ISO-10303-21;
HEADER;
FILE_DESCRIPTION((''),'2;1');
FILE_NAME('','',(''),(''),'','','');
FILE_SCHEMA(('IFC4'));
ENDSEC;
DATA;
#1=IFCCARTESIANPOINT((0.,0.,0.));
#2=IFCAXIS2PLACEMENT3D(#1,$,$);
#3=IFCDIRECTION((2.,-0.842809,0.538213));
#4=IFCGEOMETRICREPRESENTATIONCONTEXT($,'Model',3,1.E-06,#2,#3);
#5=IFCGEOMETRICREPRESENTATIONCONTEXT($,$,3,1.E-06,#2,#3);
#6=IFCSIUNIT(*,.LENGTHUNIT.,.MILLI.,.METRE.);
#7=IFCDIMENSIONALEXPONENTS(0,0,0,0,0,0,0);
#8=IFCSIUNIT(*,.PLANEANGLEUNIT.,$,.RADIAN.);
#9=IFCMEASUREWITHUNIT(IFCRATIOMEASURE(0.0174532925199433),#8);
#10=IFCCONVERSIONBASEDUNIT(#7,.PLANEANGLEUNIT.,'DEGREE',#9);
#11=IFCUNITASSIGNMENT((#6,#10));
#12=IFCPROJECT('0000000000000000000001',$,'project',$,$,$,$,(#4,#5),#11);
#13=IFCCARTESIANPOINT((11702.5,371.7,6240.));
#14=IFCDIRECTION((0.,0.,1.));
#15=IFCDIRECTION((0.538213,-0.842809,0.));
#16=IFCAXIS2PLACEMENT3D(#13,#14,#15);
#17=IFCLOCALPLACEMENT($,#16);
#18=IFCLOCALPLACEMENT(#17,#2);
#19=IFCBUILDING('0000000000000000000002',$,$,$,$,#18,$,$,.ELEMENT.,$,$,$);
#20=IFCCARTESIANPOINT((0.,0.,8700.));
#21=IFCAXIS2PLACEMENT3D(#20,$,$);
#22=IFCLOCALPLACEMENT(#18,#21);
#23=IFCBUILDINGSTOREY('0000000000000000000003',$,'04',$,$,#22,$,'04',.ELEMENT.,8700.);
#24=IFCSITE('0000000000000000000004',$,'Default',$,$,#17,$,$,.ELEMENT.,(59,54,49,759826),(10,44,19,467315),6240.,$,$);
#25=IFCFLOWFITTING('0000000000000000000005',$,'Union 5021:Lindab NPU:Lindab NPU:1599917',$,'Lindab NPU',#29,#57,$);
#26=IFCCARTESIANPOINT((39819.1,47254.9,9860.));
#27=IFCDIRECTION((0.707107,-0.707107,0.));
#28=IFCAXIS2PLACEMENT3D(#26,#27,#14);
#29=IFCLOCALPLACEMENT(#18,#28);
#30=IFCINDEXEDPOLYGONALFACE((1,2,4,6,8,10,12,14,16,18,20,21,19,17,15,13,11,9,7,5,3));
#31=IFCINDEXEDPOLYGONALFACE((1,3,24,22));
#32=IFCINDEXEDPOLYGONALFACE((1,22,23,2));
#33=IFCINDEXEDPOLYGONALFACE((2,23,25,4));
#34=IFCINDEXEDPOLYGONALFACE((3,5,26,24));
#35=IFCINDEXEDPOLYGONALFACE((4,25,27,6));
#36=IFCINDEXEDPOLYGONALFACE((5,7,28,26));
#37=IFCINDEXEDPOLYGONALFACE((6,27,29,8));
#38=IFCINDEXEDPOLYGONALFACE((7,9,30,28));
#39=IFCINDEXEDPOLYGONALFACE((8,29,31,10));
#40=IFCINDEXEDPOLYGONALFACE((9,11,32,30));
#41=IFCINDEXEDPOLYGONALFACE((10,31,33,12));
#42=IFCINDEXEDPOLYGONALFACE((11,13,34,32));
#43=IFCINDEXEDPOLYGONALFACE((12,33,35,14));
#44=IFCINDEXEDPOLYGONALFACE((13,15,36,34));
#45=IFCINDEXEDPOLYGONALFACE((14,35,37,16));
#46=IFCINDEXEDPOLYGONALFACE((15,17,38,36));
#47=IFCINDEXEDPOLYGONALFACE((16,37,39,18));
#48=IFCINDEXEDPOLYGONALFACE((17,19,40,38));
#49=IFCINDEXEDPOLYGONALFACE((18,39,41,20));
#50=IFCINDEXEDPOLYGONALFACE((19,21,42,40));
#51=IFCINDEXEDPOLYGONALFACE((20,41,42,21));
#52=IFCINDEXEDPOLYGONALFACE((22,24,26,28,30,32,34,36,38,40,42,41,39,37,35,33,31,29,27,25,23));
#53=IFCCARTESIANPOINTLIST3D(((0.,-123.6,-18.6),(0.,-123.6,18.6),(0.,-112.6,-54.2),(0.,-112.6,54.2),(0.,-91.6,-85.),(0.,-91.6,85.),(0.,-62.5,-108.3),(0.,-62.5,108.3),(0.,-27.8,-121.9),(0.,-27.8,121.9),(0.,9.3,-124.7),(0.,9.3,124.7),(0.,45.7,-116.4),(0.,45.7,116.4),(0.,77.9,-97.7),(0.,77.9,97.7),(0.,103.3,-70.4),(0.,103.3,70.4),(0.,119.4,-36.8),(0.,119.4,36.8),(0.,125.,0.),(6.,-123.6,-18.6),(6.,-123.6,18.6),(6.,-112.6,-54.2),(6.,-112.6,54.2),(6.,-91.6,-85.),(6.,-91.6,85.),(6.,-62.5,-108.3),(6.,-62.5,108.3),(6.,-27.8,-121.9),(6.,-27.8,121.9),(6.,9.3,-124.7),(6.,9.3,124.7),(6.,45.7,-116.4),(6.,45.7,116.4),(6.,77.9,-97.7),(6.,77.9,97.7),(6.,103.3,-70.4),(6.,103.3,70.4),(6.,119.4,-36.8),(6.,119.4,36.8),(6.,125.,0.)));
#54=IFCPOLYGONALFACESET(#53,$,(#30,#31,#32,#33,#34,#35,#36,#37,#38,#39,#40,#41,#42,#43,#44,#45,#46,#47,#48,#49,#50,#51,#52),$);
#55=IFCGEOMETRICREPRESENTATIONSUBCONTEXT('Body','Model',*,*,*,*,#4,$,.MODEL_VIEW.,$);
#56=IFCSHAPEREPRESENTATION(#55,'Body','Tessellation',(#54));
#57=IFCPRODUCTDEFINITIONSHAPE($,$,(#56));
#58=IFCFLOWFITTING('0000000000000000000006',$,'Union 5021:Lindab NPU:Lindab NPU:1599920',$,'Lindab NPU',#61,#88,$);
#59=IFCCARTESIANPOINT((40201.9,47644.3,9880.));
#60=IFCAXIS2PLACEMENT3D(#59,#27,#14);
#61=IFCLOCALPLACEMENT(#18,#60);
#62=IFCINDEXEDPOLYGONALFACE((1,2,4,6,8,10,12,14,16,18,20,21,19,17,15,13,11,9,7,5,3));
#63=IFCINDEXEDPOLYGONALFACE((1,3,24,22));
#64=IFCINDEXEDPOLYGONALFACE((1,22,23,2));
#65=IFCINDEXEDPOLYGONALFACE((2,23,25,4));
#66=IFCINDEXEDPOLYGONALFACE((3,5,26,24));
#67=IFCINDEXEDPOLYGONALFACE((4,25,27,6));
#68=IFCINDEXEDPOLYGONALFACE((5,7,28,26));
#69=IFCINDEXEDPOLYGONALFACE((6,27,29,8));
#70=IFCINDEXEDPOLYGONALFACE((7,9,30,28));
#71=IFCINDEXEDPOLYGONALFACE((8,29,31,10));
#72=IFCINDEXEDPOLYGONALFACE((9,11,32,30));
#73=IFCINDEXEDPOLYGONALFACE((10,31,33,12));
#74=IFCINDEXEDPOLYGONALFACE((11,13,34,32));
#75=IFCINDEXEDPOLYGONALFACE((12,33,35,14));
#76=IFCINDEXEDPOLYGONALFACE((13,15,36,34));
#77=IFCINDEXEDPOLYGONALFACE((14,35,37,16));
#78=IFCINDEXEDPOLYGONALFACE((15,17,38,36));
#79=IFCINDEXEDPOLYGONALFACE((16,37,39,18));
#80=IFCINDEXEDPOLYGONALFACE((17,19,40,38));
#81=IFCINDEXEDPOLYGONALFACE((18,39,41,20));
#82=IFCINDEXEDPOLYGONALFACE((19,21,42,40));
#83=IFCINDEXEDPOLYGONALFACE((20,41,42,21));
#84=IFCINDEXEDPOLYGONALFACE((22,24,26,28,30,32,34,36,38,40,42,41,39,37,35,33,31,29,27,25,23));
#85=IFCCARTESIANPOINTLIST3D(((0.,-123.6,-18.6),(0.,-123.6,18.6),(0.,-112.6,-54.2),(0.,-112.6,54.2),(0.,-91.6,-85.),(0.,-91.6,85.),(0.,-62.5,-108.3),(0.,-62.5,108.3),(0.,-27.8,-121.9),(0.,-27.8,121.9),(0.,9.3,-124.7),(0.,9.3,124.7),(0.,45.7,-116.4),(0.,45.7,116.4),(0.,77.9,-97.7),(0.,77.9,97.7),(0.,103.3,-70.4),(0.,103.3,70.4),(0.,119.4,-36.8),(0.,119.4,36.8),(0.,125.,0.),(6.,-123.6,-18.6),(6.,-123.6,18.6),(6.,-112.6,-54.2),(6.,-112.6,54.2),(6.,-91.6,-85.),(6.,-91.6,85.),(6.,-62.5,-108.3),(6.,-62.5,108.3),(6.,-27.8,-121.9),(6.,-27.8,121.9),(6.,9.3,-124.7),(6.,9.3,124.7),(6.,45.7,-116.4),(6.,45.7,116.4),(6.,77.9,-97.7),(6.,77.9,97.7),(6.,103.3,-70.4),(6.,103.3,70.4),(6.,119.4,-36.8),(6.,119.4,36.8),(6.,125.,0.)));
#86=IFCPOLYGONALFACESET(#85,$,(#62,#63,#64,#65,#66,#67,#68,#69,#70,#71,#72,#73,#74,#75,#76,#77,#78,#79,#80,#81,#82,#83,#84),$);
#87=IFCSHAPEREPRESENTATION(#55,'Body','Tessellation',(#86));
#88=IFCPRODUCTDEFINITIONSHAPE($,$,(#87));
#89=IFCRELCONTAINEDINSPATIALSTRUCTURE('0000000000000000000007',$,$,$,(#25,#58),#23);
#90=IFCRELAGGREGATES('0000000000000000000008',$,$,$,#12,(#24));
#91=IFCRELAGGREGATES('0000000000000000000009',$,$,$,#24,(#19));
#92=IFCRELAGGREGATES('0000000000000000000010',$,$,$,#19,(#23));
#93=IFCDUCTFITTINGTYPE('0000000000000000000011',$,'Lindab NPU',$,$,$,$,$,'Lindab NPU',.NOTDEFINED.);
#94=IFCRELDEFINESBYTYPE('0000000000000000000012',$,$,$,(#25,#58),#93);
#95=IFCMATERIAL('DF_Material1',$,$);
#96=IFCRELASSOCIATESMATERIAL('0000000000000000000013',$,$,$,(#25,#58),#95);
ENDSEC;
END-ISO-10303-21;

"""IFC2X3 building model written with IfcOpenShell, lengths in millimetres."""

from ifc_helpers import new_model, entity, si_unit, converted_unit, direction, frame, frame_2d, origin, place, context, subcontext, project, spatial, circle, extrude, source, transform, mapped, material, type_object, type_shapes, element, save


model = new_model("IFC2X3")

# Units and contexts
model_context = context("Model", 3, precision=1e-06, world=origin(), true_north=direction((2.0, -0.842809, 0.538213)))
context_of_model = context(None, 3, precision=1e-06, world=origin(), true_north=direction((2.0, -0.842809, 0.538213)))
body_context = subcontext(model_context, "Body", "Model", "MODEL_VIEW")
ifc_project = project(units=[si_unit("LENGTHUNIT", "METRE", prefix="MILLI"), converted_unit("PLANEANGLEUNIT", "DEGREE", entity("IfcRatioMeasure", 0.0174532925199433), si_unit("PLANEANGLEUNIT", "RADIAN"), dimensions=[0, 0, 0, 0, 0, 0, 0])], contexts=[model_context, context_of_model])

# Site, building, storey
site_placement = place(None, frame((11702.5, 371.7, 6240.0), z_axis=(0.0, 0.0, 1.0), x_axis=(0.538213, -0.842809, 0.0)))
site = spatial("IfcSite", under=ifc_project, at=site_placement, Name="Default", CompositionType="ELEMENT", RefLatitude=(59, 54, 49, 759826), RefLongitude=(10, 44, 19, 467315), RefElevation=6240.0)
building_placement = place(site_placement, origin())
building = spatial("IfcBuilding", under=site, at=building_placement, CompositionType="ELEMENT")
storey_placement = place(building_placement, frame((0.0, 0.0, 8700.0)))
storey = spatial("IfcBuildingStorey", under=building, at=storey_placement, Name="04", LongName="04", CompositionType="ELEMENT", Elevation=8700.0)

# Flow fittings
ifc_material = material(Name="DF_Material1")
duct_fitting_type_1 = type_object("IfcDuctFittingType", Name="Lindab NPU", ElementType="Lindab NPU", PredefinedType="NOTDEFINED")
shared_shape_1 = source(origin(), body_context, "Body", "SweptSolid", [
    extrude(circle(Radius=125.0, at=frame_2d((0.0, 0.0), x_axis=(1.0, 0.0))), frame((0.0, 0.0, 0.0), z_axis=(1.0, 0.0, 0.0), x_axis=(0.0, 1.0, 0.0)), (0.0, 0.0, 1.0), 6.0),
])
type_shapes(duct_fitting_type_1, [shared_shape_1])
for number, where, z_axis, x_axis, name in (
    (1, (39819.1, 47254.9, 9860.0), (0.707107, -0.707107, 0.0), (0.0, 0.0, 1.0), "Union 5021:Lindab NPU:Lindab NPU:1599917"),
    (2, (40201.9, 47644.3, 9880.0), (0.707107, -0.707107, 0.0), (0.0, 0.0, 1.0), "Union 5021:Lindab NPU:Lindab NPU:1599920"),
):
    element("IfcFlowFitting", number, at=place(building_placement, frame(where, z_axis=z_axis, x_axis=x_axis)), inside=storey, type_object=duct_fitting_type_1, material=ifc_material, Name=name, ObjectType="Lindab NPU", context=body_context, shape_type="MappedRepresentation", body=[
        mapped(shared_shape_1, transform((0.0, 0.0, 0.0), scale=1.0)),
    ])

save(model, "model.ifc")
